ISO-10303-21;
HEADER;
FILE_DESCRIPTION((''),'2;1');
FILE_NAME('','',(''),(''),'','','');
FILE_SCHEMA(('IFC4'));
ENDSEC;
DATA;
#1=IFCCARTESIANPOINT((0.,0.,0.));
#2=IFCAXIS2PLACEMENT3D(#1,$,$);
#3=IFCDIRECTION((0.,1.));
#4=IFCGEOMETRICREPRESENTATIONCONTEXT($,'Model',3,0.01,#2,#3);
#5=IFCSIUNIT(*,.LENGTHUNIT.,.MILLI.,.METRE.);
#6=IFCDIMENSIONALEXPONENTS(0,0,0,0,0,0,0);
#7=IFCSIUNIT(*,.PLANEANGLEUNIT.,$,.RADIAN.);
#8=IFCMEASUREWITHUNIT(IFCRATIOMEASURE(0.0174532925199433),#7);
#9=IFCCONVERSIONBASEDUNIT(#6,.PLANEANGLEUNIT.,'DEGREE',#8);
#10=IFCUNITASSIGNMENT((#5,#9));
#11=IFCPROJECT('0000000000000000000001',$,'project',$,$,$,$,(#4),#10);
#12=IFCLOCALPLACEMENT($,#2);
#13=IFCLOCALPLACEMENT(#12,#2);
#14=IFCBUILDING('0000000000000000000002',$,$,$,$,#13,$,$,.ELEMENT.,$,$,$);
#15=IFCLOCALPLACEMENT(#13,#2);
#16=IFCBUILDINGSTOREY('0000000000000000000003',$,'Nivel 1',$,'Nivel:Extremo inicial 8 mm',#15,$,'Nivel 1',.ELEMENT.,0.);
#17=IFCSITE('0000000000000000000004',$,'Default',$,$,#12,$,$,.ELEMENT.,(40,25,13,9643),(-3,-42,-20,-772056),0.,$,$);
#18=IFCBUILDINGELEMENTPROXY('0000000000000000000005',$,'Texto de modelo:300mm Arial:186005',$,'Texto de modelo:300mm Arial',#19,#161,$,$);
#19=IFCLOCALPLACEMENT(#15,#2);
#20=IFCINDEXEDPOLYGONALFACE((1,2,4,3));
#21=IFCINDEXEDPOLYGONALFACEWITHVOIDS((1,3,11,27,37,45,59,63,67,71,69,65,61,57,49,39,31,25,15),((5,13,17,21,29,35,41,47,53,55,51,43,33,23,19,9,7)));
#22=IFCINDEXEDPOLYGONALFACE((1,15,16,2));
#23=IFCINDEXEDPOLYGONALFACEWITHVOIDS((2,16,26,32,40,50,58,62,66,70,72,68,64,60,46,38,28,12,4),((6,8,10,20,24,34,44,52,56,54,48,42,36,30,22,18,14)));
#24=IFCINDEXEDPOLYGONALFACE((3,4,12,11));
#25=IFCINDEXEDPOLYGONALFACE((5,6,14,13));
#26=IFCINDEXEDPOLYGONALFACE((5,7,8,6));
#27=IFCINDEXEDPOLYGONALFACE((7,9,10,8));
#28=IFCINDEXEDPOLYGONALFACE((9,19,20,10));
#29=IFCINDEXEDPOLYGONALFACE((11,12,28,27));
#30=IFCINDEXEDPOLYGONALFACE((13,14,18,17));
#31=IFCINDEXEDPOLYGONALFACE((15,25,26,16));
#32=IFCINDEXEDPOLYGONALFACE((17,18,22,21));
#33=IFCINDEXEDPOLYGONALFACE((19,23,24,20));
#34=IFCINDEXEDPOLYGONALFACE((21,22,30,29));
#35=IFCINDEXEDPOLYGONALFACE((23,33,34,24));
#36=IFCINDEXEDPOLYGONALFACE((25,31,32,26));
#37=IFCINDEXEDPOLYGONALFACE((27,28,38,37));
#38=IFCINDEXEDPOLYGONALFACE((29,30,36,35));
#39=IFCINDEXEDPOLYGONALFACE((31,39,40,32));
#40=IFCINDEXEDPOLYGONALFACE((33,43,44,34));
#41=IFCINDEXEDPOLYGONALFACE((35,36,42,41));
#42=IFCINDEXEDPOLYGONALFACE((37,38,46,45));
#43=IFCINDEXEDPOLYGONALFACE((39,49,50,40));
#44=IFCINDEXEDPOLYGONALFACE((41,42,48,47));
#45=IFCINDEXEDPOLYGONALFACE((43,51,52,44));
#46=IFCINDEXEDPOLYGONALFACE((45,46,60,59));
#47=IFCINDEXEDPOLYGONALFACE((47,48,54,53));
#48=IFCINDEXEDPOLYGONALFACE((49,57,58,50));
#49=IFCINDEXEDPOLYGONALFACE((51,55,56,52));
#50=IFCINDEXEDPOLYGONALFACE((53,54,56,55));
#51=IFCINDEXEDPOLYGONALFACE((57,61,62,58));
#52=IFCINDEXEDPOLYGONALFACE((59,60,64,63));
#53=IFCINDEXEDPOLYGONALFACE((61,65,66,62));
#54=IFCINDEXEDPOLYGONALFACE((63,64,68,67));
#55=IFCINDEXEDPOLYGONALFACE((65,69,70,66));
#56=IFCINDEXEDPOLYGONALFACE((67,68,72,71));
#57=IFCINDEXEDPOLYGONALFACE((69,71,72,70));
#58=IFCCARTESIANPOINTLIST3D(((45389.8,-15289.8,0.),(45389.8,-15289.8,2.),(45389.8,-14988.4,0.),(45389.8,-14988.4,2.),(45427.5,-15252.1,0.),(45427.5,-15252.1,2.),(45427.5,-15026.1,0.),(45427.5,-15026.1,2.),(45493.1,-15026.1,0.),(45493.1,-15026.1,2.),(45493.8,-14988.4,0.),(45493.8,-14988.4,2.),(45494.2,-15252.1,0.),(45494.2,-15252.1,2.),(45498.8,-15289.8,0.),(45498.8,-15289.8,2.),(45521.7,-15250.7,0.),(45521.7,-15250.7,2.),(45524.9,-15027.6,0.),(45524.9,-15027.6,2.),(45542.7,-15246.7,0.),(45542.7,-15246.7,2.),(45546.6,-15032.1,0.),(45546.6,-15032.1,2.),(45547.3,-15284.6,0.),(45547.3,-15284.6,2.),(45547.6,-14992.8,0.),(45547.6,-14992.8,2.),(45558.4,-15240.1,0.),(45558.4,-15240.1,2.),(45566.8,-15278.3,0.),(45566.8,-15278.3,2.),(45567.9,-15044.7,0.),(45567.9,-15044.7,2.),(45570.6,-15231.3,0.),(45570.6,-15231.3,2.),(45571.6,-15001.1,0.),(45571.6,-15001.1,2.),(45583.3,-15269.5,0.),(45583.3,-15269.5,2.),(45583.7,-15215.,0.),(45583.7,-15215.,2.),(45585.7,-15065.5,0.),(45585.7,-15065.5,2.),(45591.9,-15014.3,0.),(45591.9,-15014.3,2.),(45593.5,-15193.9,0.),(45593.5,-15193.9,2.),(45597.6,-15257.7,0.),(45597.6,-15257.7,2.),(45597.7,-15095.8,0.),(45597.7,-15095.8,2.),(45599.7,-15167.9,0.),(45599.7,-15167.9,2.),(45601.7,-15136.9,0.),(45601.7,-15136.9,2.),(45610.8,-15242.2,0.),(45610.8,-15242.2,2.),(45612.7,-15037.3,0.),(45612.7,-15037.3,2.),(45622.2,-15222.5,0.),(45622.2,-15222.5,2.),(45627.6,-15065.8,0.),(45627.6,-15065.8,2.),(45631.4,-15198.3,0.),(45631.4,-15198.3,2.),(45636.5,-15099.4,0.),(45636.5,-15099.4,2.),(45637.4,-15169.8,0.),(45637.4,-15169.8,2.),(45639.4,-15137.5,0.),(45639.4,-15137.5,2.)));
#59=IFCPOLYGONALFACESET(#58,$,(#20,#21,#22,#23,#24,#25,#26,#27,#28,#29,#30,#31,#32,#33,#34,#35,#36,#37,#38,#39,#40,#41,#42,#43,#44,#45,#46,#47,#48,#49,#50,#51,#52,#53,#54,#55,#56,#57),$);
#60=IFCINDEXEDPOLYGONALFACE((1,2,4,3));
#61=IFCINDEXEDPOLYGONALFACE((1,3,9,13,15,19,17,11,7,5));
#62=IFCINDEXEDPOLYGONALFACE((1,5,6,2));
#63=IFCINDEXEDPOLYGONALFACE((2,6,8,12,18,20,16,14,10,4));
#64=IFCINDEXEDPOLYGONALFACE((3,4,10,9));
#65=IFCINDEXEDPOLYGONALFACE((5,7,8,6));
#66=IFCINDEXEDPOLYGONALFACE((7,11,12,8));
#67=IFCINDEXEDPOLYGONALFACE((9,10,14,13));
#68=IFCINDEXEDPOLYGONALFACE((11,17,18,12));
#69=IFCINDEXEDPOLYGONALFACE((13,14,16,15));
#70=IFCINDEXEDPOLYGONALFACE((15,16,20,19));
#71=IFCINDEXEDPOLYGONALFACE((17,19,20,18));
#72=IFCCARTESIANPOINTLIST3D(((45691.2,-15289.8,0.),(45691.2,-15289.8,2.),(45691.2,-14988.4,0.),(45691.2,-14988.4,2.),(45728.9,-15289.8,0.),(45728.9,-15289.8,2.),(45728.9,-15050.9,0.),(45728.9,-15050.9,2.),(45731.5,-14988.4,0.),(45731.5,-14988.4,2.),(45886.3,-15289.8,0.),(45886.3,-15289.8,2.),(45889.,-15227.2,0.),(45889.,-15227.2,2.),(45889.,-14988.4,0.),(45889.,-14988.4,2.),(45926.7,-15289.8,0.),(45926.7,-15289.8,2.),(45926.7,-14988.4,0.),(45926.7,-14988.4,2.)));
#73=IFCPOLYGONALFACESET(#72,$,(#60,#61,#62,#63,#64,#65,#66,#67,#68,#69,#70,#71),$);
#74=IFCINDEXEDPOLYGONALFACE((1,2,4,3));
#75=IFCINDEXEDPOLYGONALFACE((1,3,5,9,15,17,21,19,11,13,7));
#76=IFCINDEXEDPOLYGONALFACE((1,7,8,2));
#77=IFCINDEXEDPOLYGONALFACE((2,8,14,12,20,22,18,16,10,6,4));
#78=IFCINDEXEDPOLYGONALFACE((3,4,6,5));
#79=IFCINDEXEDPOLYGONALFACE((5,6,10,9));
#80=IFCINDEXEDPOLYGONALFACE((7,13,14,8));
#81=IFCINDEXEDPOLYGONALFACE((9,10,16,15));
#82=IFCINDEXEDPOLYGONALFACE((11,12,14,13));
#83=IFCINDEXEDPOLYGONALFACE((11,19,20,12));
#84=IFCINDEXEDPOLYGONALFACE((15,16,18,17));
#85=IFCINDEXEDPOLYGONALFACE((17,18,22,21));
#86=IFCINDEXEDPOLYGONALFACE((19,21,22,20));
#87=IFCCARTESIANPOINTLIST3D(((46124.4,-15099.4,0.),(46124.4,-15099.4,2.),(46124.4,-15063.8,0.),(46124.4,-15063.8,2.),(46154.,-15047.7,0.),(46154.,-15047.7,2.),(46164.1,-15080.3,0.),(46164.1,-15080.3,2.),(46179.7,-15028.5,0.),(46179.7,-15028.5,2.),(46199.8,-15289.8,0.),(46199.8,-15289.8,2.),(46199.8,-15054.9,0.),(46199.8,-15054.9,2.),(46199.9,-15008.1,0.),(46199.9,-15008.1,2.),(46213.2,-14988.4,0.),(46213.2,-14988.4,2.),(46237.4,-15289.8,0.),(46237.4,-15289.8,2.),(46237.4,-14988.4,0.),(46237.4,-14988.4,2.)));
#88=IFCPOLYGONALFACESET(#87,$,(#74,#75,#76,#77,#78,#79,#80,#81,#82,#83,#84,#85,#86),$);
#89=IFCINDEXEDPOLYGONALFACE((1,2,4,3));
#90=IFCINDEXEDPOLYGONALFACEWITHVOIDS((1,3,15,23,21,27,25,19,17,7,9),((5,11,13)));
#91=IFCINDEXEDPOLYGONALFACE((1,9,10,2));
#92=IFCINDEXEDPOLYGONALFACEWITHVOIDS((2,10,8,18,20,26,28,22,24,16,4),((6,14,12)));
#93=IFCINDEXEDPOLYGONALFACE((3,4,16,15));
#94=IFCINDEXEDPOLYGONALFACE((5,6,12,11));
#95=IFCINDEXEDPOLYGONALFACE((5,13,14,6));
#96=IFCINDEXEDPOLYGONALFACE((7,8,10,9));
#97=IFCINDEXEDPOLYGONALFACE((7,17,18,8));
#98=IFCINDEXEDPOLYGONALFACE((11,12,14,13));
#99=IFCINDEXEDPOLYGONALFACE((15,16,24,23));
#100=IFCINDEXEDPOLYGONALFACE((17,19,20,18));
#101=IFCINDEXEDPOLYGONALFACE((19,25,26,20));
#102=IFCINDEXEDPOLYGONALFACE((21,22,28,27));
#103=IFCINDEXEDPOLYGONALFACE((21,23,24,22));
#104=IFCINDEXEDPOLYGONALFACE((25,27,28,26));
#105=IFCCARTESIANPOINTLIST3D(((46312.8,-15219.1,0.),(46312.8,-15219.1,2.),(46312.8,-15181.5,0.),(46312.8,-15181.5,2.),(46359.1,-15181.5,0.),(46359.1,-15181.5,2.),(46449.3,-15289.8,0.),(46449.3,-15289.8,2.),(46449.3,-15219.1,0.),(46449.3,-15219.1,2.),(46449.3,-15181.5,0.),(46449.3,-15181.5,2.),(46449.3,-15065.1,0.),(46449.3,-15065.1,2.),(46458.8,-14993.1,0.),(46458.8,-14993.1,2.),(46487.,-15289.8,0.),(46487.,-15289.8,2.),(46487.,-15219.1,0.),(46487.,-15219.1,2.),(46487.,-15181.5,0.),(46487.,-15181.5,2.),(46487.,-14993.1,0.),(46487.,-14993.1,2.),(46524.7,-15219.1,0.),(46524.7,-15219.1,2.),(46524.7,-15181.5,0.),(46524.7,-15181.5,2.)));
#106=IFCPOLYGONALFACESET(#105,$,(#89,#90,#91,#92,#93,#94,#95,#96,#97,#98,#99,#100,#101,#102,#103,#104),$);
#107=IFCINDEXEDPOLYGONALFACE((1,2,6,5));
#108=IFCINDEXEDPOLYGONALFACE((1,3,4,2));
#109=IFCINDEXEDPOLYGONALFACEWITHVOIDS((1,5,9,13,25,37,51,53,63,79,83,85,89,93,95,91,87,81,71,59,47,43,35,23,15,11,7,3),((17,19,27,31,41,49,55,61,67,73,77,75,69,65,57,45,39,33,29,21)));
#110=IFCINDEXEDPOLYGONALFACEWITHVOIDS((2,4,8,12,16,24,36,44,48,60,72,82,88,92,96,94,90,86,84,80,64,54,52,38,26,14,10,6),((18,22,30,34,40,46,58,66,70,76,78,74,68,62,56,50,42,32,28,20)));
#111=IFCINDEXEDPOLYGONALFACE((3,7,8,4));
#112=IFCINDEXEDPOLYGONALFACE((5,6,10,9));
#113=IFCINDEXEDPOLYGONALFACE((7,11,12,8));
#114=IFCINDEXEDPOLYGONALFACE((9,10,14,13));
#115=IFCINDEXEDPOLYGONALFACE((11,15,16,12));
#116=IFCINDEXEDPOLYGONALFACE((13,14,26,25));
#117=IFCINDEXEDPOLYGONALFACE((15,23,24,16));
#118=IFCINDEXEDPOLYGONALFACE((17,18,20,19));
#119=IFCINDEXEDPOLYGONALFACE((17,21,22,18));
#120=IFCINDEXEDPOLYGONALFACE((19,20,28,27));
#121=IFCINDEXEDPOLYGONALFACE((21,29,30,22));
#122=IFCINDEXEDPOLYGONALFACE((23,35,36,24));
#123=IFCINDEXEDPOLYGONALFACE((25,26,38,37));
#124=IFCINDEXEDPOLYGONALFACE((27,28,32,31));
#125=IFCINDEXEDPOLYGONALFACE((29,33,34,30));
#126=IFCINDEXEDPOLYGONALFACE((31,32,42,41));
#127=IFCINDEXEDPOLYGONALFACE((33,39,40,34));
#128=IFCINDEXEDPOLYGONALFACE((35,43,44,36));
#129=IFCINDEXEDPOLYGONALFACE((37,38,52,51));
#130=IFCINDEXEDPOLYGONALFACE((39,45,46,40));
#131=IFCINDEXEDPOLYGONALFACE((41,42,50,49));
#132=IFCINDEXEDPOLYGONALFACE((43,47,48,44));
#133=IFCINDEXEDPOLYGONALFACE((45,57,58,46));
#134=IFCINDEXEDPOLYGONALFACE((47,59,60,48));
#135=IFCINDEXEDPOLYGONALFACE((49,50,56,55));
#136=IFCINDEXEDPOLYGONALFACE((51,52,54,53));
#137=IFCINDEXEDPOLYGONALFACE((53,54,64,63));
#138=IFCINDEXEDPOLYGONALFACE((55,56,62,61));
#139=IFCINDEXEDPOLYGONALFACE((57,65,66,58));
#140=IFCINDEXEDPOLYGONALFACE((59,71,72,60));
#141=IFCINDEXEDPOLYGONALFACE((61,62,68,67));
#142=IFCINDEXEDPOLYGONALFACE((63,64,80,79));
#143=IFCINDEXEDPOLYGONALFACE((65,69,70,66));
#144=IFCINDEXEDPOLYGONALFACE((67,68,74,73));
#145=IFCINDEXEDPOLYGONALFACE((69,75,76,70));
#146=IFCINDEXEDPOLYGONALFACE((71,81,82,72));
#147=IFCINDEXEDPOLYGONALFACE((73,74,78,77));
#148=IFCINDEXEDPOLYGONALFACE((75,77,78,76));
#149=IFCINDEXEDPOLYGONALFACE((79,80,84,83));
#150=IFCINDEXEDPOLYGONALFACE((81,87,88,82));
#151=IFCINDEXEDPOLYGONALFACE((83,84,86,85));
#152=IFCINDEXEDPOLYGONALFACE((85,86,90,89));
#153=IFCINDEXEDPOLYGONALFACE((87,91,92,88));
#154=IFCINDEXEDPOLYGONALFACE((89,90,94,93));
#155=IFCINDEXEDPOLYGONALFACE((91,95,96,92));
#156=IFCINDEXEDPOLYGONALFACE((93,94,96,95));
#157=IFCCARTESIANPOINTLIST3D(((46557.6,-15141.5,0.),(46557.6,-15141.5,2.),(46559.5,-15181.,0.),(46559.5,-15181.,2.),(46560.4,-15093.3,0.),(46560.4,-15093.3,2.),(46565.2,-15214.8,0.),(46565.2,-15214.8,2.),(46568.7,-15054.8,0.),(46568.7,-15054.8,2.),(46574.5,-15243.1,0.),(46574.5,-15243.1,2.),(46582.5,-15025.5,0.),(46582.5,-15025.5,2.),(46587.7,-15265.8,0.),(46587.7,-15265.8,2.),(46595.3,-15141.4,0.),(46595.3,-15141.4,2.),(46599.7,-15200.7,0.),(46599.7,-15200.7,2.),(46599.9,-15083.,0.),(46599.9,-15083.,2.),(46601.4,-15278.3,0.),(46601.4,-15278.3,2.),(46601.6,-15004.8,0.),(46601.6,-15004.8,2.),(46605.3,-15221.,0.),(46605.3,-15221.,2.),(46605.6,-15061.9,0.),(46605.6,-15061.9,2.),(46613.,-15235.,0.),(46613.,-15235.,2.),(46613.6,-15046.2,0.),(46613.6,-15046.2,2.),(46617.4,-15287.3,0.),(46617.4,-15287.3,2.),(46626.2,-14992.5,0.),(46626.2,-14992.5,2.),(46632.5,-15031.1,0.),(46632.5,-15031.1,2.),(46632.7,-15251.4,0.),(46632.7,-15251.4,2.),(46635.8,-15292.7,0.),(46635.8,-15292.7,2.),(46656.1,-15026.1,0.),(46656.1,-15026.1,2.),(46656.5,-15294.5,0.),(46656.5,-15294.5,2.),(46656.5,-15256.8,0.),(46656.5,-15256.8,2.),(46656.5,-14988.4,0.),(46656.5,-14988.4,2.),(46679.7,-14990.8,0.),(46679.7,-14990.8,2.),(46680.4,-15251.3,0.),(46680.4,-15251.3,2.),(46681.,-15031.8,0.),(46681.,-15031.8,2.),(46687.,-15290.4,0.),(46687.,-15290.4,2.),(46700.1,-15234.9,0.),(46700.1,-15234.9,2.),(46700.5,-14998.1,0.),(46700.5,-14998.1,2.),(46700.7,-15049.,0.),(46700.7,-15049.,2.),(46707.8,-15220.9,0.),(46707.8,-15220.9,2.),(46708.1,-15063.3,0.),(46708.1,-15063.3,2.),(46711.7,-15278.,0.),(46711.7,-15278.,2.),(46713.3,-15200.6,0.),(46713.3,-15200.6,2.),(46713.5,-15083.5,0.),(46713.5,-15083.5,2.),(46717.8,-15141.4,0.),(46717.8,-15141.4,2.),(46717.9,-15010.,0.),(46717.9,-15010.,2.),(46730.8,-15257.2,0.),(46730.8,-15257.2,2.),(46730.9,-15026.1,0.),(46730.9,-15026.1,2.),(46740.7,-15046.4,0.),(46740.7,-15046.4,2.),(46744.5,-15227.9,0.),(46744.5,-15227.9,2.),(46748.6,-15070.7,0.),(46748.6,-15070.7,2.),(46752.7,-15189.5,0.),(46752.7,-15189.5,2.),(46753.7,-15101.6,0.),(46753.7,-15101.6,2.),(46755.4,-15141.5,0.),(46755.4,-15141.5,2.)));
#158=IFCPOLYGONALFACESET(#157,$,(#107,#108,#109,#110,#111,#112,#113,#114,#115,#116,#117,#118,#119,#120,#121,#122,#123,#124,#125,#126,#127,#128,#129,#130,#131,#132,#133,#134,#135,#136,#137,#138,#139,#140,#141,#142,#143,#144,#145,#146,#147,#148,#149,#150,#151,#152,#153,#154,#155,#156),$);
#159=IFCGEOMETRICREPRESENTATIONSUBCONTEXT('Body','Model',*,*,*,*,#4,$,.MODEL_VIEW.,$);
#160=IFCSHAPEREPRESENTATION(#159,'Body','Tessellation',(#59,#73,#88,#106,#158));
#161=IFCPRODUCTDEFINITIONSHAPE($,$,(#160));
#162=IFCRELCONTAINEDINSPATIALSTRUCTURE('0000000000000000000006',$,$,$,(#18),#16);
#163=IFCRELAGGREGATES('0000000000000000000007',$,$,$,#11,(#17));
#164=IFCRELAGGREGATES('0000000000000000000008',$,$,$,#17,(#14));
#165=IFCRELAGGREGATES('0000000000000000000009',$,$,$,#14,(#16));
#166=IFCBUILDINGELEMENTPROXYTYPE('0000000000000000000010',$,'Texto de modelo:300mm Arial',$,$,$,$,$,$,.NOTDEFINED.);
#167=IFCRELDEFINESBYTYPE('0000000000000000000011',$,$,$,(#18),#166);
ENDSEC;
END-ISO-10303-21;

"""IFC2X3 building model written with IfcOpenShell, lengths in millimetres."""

from ifc_helpers import new_model, entity, si_unit, converted_unit, direction, frame, origin, place, context, subcontext, project, spatial, polyline, outline, extrude, type_object, element, save


model = new_model("IFC2X3")

# Units and contexts
model_context = context("Model", 3, precision=0.01, world=origin(), true_north=direction((0.0, 1.0)))
body_context = subcontext(model_context, "Body", "Model", "MODEL_VIEW")
ifc_project = project(units=[si_unit("LENGTHUNIT", "METRE", prefix="MILLI"), converted_unit("PLANEANGLEUNIT", "DEGREE", entity("IfcRatioMeasure", 0.0174532925199433), si_unit("PLANEANGLEUNIT", "RADIAN"), dimensions=[0, 0, 0, 0, 0, 0, 0])], contexts=[model_context])

# Site, building, storey
site_placement = place(None, origin())
site = spatial("IfcSite", under=ifc_project, at=site_placement, Name="Default", CompositionType="ELEMENT", RefLatitude=(40, 25, 13, 9643), RefLongitude=(-3, -42, -20, -772056), RefElevation=0.0)
building_placement = place(site_placement, origin())
building = spatial("IfcBuilding", under=site, at=building_placement, CompositionType="ELEMENT")
storey_placement = place(building_placement, origin())
storey = spatial("IfcBuildingStorey", under=building, at=storey_placement, Name="Nivel 1", ObjectType="Nivel:Extremo inicial 8 mm", LongName="Nivel 1", CompositionType="ELEMENT", Elevation=0.0)

# Building element proxy
building_element_proxy_type_1 = type_object("IfcBuildingElementProxyType", Name="Texto de modelo:300mm Arial", PredefinedType="NOTDEFINED")
proxy_1_placement = place(storey_placement, frame((45389.8, -15294.5, 0.0)))
element("IfcBuildingElementProxy", 1, at=proxy_1_placement, inside=storey, type_object=building_element_proxy_type_1, Name="Texto de modelo:300mm Arial:186005", ObjectType="Texto de modelo:300mm Arial", context=body_context, shape_type="SweptSolid", body=[
    extrude(outline(polyline([(-178.4, -141.0), (-69.4, -141.0), (-21.0, -135.8), (-1.4, -129.5), (15.0, -120.7), (29.4, -108.9), (42.6, -93.4), (54.0, -73.7), (63.2, -49.5), (69.2, -21.0), (71.2, 11.3), (68.2, 49.4), (59.3, 83.0), (44.5, 111.5), (23.7, 134.5), (3.4, 147.7), (-20.6, 156.1), (-74.4, 160.4), (-178.4, 160.4), (-178.4, -141.0)]), holes=[polyline([(-140.7, -103.3), (-140.7, 122.7), (-75.1, 122.7), (-43.3, 121.2), (-21.7, 116.7), (-0.4, 104.1), (17.4, 83.3), (29.5, 53.0), (33.5, 11.9), (31.5, -19.1), (25.3, -45.1), (15.5, -66.2), (2.4, -82.5), (-9.8, -91.3), (-25.6, -97.9), (-46.5, -101.9), (-74.1, -103.3), (-140.7, -103.3)])]), frame((178.4, 145.7, 0.0)), (0.0, 0.0, 1.0), 2.0),
    extrude(outline(polyline([(-117.7, -150.7), (-80.1, -150.7), (-80.1, 88.1), (77.4, -150.7), (117.7, -150.7), (117.7, 150.7), (80.1, 150.7), (80.1, -88.1), (-77.4, 150.7), (-117.7, 150.7), (-117.7, -150.7)])), frame((419.1, 155.4, 0.0)), (0.0, 0.0, 1.0), 2.0),
    extrude(outline(polyline([(-204.4, -52.5), (97.0, -52.5), (97.0, -28.2), (77.2, -14.9), (56.9, 5.3), (37.7, 30.9), (21.6, 60.5), (-14.0, 60.5), (5.0, 20.8), (30.4, -14.9), (-204.4, -14.9), (-204.4, -52.5)])), frame((795.1, 209.1, 0.0), z_axis=(0.0, 0.0, 1.0), x_axis=(0.0, 1.0, 0.0)), (0.0, 0.0, 1.0), 2.0),
    extrude(outline(polyline([(-3.4, -109.2), (34.2, -109.2), (34.2, -38.5), (71.9, -38.5), (71.9, -0.9), (34.2, -0.9), (34.2, 187.5), (6.0, 187.5), (-140.0, -0.9), (-140.0, -38.5), (-3.4, -38.5), (-3.4, -109.2)]), holes=[polyline([(-3.4, -0.9), (-93.6, -0.9), (-3.4, 115.5), (-3.4, -0.9)])]), frame((1062.9, 113.9, 0.0)), (0.0, 0.0, 1.0), 2.0),
    extrude(outline(polyline([(-5.6, -99.5), (33.9, -99.5), (68.0, -95.5), (96.7, -87.5), (120.0, -75.5), (133.2, -62.4), (142.9, -46.8), (149.1, -28.7), (151.9, -8.0), (149.2, 22.6), (138.0, 47.8), (118.2, 67.9), (89.5, 82.9), (51.6, 93.0), (3.8, 98.0), (-36.2, 98.2), (-67.3, 94.5), (-91.9, 87.9), (-112.6, 79.0), (-129.4, 66.8), (-142.0, 50.0), (-150.3, 29.6), (-153.8, 6.5), (-151.2, -23.9), (-140.1, -49.1), (-120.3, -69.2), (-91.7, -84.4), (-53.6, -94.5), (-5.6, -99.5)]), holes=[polyline([(-3.9, -61.9), (-62.1, -54.6), (-82.9, -47.9), (-98.1, -39.2), (-112.3, -19.5), (-116.2, 4.3), (-109.3, 28.9), (-91.2, 47.7), (-76.5, 54.5), (-56.1, 58.9), (1.9, 60.4), (60.8, 53.2), (80.8, 46.7), (94.5, 38.3), (109.9, 17.8), (114.3, -6.3), (107.7, -29.8), (90.4, -48.7), (76.0, -55.8), (55.5, -60.3), (-3.9, -61.9)])]), frame((1267.5, 152.1, 0.0), z_axis=(0.0, 0.0, 1.0), x_axis=(0.047515, -0.998871, 0.0)), (0.0, 0.0, 1.0), 2.0),
])

save(model, "model.ifc")
